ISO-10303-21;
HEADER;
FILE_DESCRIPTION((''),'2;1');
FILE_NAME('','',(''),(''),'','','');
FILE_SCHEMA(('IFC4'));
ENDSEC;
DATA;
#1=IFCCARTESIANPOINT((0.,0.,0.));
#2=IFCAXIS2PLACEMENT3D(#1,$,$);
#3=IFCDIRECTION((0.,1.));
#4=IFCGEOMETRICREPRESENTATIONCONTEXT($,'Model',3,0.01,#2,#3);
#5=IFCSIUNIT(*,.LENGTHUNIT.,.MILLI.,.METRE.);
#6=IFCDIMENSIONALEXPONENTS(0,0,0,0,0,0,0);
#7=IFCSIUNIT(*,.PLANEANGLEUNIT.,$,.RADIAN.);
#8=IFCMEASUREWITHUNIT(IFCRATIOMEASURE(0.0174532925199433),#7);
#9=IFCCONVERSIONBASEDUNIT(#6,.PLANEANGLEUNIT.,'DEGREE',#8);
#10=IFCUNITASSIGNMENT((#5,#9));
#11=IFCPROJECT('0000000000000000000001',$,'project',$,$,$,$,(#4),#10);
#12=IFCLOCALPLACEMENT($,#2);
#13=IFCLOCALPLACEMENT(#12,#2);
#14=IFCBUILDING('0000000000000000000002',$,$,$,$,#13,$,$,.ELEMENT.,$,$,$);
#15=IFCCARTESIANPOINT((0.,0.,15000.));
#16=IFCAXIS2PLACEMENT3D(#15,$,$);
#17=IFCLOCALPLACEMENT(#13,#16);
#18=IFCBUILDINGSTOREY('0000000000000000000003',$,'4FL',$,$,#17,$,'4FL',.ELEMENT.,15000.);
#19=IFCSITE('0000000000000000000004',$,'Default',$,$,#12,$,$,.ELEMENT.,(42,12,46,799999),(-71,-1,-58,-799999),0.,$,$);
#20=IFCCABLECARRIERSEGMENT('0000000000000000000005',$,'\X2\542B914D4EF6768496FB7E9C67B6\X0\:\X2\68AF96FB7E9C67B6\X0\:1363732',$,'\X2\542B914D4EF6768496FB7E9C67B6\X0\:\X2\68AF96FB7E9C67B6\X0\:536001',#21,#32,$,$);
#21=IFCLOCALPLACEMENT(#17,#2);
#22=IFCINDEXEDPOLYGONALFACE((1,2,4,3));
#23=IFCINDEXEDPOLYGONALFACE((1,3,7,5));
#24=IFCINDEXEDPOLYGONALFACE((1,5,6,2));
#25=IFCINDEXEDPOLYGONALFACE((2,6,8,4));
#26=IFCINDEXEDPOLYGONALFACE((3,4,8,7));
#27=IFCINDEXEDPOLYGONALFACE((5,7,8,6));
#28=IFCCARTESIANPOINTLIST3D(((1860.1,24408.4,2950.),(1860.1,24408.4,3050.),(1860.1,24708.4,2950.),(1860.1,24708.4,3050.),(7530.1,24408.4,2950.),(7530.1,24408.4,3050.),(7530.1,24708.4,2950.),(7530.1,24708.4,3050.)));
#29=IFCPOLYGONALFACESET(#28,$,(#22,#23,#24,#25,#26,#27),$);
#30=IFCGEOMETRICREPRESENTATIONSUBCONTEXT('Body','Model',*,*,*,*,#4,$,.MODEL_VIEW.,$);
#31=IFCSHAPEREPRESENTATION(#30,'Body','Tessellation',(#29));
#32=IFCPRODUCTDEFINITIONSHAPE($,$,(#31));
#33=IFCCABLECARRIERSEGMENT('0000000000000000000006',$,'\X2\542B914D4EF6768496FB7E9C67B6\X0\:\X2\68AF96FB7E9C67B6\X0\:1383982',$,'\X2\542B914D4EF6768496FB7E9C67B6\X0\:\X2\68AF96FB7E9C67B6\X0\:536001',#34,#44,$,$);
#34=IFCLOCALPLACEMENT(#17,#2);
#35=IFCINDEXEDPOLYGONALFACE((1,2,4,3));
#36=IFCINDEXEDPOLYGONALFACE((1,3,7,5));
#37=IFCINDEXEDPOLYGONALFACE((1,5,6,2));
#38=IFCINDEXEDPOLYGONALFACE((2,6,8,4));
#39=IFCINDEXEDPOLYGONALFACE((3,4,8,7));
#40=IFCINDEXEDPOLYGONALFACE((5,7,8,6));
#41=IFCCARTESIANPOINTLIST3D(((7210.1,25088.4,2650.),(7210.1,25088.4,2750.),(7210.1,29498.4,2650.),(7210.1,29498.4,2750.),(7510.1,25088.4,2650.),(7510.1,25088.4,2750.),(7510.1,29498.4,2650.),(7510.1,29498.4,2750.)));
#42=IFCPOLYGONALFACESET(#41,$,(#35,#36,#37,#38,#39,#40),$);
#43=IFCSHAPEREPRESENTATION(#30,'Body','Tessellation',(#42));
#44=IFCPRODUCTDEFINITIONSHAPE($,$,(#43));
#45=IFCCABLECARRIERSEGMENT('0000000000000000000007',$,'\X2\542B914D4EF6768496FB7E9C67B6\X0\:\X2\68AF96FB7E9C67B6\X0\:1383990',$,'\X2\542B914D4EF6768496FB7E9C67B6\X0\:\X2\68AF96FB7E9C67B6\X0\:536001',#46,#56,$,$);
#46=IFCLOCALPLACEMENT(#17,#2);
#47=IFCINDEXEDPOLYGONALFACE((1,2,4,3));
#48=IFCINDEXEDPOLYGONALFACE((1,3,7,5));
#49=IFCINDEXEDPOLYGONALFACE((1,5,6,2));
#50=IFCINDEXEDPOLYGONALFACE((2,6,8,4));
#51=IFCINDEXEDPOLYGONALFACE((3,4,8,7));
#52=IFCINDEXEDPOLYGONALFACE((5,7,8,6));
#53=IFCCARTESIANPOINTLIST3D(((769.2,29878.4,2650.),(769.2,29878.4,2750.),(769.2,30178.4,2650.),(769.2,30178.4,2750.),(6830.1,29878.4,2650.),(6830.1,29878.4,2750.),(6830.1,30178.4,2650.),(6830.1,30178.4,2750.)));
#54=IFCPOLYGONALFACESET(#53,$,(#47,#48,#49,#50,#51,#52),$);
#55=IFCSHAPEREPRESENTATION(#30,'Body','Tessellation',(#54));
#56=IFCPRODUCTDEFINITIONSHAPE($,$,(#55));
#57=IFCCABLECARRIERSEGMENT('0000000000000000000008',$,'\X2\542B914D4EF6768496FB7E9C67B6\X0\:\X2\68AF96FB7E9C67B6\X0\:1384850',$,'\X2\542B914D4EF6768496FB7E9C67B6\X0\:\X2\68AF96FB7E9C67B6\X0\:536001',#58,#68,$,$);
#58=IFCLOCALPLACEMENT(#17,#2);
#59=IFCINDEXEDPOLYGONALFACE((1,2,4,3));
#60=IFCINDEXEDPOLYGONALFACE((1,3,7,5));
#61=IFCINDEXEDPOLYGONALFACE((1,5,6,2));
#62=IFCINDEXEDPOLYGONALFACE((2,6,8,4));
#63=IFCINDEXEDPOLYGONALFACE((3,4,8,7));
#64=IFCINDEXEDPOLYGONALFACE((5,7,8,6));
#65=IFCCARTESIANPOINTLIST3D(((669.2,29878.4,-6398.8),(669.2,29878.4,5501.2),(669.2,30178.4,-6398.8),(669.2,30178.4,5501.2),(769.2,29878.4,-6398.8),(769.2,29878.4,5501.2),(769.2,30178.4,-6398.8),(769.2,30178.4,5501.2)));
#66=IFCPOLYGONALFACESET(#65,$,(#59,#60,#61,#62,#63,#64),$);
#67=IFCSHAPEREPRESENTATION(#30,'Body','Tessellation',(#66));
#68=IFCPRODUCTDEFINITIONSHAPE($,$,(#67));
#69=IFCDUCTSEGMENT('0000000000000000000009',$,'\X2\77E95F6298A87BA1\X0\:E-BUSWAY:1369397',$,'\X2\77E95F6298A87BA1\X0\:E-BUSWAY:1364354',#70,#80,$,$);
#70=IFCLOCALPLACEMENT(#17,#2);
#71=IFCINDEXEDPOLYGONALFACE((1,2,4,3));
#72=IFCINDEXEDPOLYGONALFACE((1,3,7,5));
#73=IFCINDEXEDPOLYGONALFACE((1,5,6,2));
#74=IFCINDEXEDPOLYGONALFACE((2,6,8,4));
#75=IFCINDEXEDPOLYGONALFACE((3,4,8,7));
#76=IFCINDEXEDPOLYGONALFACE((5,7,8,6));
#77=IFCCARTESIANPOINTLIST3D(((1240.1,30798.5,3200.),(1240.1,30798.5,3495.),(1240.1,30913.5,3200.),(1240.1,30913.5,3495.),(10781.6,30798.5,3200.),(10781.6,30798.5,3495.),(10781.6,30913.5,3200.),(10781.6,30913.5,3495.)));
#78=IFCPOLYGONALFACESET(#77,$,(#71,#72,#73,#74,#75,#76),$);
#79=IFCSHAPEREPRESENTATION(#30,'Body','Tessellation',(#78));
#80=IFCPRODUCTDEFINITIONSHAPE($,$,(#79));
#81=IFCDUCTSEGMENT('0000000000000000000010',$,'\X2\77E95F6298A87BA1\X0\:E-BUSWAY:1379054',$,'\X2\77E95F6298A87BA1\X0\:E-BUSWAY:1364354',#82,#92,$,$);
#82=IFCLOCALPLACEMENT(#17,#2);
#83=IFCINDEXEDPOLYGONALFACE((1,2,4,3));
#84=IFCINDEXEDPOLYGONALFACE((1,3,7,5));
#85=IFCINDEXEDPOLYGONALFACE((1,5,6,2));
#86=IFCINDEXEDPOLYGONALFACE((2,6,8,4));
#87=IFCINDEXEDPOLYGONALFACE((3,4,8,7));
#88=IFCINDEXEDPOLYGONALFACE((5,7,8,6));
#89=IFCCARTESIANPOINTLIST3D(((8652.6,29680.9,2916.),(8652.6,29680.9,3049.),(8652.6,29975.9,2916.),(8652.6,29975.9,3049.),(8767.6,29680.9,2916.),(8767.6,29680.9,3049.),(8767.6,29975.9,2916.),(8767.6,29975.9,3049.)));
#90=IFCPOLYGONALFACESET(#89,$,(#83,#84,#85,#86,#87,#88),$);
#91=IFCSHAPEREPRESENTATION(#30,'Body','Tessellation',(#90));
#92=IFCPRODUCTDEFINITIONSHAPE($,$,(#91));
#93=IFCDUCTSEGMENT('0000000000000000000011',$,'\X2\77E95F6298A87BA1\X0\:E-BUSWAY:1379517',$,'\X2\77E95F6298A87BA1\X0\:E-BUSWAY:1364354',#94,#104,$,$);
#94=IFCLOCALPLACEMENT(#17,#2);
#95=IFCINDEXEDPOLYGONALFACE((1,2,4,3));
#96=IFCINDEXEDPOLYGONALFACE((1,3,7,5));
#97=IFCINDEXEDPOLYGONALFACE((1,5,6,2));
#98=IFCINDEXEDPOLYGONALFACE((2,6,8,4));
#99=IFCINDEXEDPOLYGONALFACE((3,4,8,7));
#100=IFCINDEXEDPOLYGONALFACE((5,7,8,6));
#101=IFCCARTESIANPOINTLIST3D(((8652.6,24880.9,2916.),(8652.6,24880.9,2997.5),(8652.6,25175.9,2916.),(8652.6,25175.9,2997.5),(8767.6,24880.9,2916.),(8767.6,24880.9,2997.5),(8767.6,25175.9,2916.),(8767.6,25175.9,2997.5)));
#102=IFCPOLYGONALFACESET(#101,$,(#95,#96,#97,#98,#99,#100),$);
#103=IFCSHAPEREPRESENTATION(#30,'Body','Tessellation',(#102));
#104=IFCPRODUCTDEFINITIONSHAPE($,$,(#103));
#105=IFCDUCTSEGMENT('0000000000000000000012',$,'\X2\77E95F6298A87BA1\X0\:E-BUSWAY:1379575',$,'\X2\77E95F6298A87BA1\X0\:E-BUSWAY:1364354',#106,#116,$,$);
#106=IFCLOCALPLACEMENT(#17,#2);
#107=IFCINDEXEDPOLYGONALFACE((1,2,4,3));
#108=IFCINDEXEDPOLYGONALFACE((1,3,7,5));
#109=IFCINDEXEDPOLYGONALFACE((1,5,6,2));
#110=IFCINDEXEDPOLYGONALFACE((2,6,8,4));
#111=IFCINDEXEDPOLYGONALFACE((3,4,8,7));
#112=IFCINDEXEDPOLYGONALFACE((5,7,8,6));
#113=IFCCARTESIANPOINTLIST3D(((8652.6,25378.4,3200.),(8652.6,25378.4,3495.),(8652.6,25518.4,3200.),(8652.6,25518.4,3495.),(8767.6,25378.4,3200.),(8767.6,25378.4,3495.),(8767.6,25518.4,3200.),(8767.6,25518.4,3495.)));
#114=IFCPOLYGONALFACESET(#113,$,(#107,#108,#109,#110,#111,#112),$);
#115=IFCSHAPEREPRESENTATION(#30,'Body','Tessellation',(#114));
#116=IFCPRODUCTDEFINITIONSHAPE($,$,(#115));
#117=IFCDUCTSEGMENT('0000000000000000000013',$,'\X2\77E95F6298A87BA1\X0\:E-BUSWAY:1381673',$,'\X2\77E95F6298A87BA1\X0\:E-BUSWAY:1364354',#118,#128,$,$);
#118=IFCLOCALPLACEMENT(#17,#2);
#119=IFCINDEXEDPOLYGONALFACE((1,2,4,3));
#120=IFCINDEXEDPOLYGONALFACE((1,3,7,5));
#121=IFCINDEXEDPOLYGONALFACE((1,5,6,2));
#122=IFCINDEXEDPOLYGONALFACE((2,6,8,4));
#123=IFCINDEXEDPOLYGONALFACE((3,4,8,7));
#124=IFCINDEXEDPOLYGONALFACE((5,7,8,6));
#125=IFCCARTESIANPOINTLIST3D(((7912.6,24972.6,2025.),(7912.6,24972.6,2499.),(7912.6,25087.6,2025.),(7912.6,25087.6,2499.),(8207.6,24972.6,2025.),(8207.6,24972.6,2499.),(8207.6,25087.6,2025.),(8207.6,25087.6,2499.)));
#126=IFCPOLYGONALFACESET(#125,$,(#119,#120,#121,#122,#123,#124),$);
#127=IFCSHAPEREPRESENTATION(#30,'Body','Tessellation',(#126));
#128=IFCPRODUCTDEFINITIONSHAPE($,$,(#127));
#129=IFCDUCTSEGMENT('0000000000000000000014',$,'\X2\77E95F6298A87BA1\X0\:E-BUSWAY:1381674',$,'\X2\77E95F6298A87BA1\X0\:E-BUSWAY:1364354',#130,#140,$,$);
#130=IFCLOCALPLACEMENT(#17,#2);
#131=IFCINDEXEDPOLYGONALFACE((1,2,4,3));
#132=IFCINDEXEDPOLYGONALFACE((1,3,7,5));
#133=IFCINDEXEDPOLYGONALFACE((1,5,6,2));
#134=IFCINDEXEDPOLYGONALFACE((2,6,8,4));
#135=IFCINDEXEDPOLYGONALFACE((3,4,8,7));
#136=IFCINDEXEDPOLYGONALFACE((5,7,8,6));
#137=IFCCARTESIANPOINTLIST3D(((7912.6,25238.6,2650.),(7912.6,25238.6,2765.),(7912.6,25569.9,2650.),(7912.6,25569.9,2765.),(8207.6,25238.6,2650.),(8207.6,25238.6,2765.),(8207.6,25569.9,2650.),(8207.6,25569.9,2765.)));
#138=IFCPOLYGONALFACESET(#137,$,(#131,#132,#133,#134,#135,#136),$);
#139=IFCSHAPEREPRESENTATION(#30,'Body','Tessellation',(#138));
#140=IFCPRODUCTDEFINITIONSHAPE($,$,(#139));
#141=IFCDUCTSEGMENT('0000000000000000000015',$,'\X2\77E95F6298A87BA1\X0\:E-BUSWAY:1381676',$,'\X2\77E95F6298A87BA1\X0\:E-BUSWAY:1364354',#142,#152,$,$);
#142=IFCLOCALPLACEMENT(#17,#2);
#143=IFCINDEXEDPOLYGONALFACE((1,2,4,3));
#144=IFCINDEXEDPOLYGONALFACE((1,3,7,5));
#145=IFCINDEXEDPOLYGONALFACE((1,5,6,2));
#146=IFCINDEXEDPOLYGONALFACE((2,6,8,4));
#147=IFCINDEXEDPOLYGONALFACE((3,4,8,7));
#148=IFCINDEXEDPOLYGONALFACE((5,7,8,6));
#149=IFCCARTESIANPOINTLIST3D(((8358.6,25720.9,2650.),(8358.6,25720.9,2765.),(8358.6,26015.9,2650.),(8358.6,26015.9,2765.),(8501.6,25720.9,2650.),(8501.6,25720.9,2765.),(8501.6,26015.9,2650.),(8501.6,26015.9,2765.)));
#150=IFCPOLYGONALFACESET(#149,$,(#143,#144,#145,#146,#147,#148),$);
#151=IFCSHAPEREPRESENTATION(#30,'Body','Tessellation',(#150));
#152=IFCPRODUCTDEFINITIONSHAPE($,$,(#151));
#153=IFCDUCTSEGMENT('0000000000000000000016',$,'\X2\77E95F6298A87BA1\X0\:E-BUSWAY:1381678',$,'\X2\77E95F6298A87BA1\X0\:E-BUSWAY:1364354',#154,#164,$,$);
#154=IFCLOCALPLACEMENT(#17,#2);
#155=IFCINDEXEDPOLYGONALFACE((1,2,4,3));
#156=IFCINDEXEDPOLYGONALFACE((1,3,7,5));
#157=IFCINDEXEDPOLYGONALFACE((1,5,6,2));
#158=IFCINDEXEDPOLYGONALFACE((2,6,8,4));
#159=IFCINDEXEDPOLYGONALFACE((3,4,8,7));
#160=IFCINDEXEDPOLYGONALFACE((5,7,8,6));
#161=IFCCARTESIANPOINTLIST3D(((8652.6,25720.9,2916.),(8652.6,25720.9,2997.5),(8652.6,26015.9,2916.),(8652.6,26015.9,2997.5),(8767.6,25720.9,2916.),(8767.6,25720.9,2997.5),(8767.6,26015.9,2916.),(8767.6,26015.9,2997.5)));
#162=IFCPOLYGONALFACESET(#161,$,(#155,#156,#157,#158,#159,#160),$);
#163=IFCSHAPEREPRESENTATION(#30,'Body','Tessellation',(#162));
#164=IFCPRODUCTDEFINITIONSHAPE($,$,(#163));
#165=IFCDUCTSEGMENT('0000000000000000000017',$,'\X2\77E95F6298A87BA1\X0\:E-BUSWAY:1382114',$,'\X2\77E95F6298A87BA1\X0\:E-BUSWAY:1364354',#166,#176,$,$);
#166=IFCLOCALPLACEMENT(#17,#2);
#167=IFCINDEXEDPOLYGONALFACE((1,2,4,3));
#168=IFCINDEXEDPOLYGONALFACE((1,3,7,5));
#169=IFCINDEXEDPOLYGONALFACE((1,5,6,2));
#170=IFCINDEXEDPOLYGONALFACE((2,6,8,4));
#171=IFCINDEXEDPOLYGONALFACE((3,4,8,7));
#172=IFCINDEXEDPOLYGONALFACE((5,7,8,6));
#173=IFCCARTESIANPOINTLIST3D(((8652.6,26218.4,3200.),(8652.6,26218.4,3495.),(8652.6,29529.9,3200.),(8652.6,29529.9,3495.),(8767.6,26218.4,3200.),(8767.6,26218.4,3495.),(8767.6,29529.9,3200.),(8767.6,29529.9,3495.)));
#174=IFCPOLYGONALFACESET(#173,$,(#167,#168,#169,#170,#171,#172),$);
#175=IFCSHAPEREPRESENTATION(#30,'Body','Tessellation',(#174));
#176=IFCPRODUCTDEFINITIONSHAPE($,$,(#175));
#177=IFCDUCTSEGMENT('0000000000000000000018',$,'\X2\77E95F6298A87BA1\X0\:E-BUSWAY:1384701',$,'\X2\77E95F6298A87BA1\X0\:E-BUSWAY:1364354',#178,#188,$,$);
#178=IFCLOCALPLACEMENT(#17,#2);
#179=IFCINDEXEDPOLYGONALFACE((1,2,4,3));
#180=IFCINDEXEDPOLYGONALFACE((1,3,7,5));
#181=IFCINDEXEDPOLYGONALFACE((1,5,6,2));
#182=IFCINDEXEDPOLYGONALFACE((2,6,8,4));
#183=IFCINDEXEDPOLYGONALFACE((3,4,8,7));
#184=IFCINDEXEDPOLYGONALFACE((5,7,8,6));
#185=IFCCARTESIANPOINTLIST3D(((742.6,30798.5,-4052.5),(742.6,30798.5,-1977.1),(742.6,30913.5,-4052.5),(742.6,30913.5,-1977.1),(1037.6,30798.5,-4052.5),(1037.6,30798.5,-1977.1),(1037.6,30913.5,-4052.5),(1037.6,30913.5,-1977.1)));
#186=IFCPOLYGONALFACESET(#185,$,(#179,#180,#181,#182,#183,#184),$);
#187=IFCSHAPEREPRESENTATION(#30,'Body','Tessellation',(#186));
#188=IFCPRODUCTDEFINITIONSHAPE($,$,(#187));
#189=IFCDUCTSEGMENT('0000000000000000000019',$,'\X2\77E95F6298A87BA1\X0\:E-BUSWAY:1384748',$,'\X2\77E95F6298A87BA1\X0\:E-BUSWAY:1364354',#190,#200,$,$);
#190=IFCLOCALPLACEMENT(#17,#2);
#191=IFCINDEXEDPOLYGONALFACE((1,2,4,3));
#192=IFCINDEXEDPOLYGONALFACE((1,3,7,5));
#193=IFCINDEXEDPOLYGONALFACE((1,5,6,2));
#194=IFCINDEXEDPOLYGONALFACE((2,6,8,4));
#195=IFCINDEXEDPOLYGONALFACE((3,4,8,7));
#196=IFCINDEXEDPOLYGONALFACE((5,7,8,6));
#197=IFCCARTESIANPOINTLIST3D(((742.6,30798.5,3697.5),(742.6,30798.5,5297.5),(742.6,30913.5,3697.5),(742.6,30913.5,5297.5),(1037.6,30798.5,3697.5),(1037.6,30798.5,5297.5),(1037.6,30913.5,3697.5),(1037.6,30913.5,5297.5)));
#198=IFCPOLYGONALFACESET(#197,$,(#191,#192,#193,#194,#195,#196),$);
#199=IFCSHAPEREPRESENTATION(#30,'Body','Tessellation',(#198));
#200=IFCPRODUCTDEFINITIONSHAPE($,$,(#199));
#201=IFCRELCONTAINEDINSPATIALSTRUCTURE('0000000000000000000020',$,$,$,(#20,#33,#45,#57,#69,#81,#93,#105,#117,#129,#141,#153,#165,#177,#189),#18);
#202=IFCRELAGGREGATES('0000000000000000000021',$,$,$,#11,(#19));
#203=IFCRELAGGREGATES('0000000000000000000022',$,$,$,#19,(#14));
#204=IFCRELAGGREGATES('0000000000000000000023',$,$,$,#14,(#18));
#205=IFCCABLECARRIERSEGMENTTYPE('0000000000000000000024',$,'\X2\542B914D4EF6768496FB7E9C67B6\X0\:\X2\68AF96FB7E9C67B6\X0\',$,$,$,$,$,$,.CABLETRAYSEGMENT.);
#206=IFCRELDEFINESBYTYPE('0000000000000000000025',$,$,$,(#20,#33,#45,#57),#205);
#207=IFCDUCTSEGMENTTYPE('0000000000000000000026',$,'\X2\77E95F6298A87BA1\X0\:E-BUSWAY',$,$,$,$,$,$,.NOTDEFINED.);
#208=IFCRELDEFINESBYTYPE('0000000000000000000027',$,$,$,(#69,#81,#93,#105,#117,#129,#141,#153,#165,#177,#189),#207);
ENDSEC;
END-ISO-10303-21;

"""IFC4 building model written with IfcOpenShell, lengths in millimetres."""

from ifc_helpers import new_model, entity, si_unit, converted_unit, direction, frame, frame_2d, origin, origin_2d_with_axis, place, context, subcontext, project, spatial, rectangle, extrude, type_object, element, save


model = new_model("IFC4")

# Units and contexts
model_context = context("Model", 3, precision=0.01, world=origin(), true_north=direction((0.0, 1.0)))
body_context = subcontext(model_context, "Body", "Model", "MODEL_VIEW")
ifc_project = project(units=[si_unit("LENGTHUNIT", "METRE", prefix="MILLI"), converted_unit("PLANEANGLEUNIT", "DEGREE", entity("IfcRatioMeasure", 0.0174532925199433), si_unit("PLANEANGLEUNIT", "RADIAN"), dimensions=[0, 0, 0, 0, 0, 0, 0])], contexts=[model_context])

# Site, building, storey
site_placement = place(None, origin())
site = spatial("IfcSite", under=ifc_project, at=site_placement, Name="Default", CompositionType="ELEMENT", RefLatitude=(42, 12, 46, 799999), RefLongitude=(-71, -1, -58, -799999), RefElevation=0.0)
building_placement = place(site_placement, origin())
building = spatial("IfcBuilding", under=site, at=building_placement, CompositionType="ELEMENT")
storey_placement = place(building_placement, frame((0.0, 0.0, 15000.0)))
storey = spatial("IfcBuildingStorey", under=building, at=storey_placement, Name="4FL", LongName="4FL", CompositionType="ELEMENT", Elevation=15000.0)

# Cable carrier segments
cable_carrier_segment_type_1 = type_object("IfcCableCarrierSegmentType", Name="含配件的電纜架:梯電纜架", PredefinedType="CABLETRAYSEGMENT")
cable_carrier_segment_1_placement = place(storey_placement, frame((1860.1, 24408.4, 2950.0)))
element("IfcCableCarrierSegment", 1, at=cable_carrier_segment_1_placement, inside=storey, type_object=cable_carrier_segment_type_1, Name="含配件的電纜架:梯電纜架:1363732", ObjectType="含配件的電纜架:梯電纜架:536001", context=body_context, shape_type="SweptSolid", body=[
    extrude(rectangle(XDim=5670.0, YDim=300.0, at=origin_2d_with_axis()), frame((2835.0, 150.0, 0.0)), (0.0, 0.0, 1.0), 100.0),
])
cable_carrier_segment_2_placement = place(storey_placement, frame((7210.1, 25088.4, 2650.0)))
element("IfcCableCarrierSegment", 2, at=cable_carrier_segment_2_placement, inside=storey, type_object=cable_carrier_segment_type_1, Name="含配件的電纜架:梯電纜架:1383982", ObjectType="含配件的電纜架:梯電纜架:536001", context=body_context, shape_type="SweptSolid", body=[
    extrude(rectangle(XDim=4410.0, YDim=300.0, at=frame_2d((0.0, 0.0), x_axis=(1.0, 0.0))), frame((150.0, 2205.0, 0.0), z_axis=(0.0, 0.0, 1.0), x_axis=(0.0, 1.0, 0.0)), (0.0, 0.0, 1.0), 100.0),
])
cable_carrier_segment_3_placement = place(storey_placement, frame((769.2, 29878.4, 2650.0)))
element("IfcCableCarrierSegment", 3, at=cable_carrier_segment_3_placement, inside=storey, type_object=cable_carrier_segment_type_1, Name="含配件的電纜架:梯電纜架:1383990", ObjectType="含配件的電纜架:梯電纜架:536001", context=body_context, shape_type="SweptSolid", body=[
    extrude(rectangle(XDim=300.0, YDim=6060.9, at=frame_2d((0.0, 0.0), x_axis=(1.0, 0.0))), frame((3030.5, 150.0, 0.0), z_axis=(0.0, 0.0, 1.0), x_axis=(0.0, -1.0, 0.0)), (0.0, 0.0, 1.0), 100.0),
])
cable_carrier_segment_4_placement = place(storey_placement, frame((669.2, 29878.4, -6398.8)))
element("IfcCableCarrierSegment", 4, at=cable_carrier_segment_4_placement, inside=storey, type_object=cable_carrier_segment_type_1, Name="含配件的電纜架:梯電纜架:1384850", ObjectType="含配件的電纜架:梯電纜架:536001", context=body_context, shape_type="SweptSolid", body=[
    extrude(rectangle(XDim=100.0, YDim=300.0, at=origin_2d_with_axis()), frame((50.0, 150.0, 0.0)), (0.0, 0.0, 1.0), 11900.0),
])

# Duct segments
duct_segment_type = type_object("IfcDuctSegmentType", Name="矩形風管:E-BUSWAY", PredefinedType="NOTDEFINED")
duct_segment_1_placement = place(storey_placement, frame((1240.1, 30798.5, 3200.0)))
element("IfcDuctSegment", 5, at=duct_segment_1_placement, inside=storey, type_object=duct_segment_type, Name="矩形風管:E-BUSWAY:1369397", ObjectType="矩形風管:E-BUSWAY:1364354", context=body_context, shape_type="SweptSolid", body=[
    extrude(rectangle(XDim=9541.5, YDim=115.0, at=frame_2d((0.0, 0.0), x_axis=(1.0, 0.0))), frame((4770.8, 57.5, 0.0)), (0.0, 0.0, 1.0), 295.0),
])
duct_segment_2_placement = place(storey_placement, frame((8652.6, 29680.9, 2916.0)))
element("IfcDuctSegment", 6, at=duct_segment_2_placement, inside=storey, type_object=duct_segment_type, Name="矩形風管:E-BUSWAY:1379054", ObjectType="矩形風管:E-BUSWAY:1364354", context=body_context, shape_type="SweptSolid", body=[
    extrude(rectangle(XDim=115.0, YDim=295.0, at=frame_2d((0.0, 0.0), x_axis=(1.0, 0.0))), frame((57.5, 147.5, 0.0), z_axis=(0.0, 0.0, 1.0), x_axis=(-1.0, 0.0, 0.0)), (0.0, 0.0, 1.0), 133.0),
])
duct_segment_3_placement = place(storey_placement, frame((8652.6, 24880.9, 2916.0)))
element("IfcDuctSegment", 7, at=duct_segment_3_placement, inside=storey, type_object=duct_segment_type, Name="矩形風管:E-BUSWAY:1379517", ObjectType="矩形風管:E-BUSWAY:1364354", context=body_context, shape_type="SweptSolid", body=[
    extrude(rectangle(XDim=115.0, YDim=295.0, at=frame_2d((0.0, 0.0), x_axis=(1.0, 0.0))), frame((57.5, 147.5, 0.0), z_axis=(0.0, 0.0, 1.0), x_axis=(-1.0, 0.0, 0.0)), (0.0, 0.0, 1.0), 81.5),
])
duct_segment_4_placement = place(storey_placement, frame((8652.6, 25378.4, 3200.0)))
element("IfcDuctSegment", 8, at=duct_segment_4_placement, inside=storey, type_object=duct_segment_type, Name="矩形風管:E-BUSWAY:1379575", ObjectType="矩形風管:E-BUSWAY:1364354", context=body_context, shape_type="SweptSolid", body=[
    extrude(rectangle(XDim=140.0, YDim=115.0, at=frame_2d((0.0, 0.0), x_axis=(1.0, 0.0))), frame((57.5, 70.0, 0.0), z_axis=(0.0, 0.0, 1.0), x_axis=(0.0, -1.0, 0.0)), (0.0, 0.0, 1.0), 295.0),
])
duct_segment_5_placement = place(storey_placement, frame((7912.6, 24972.6, 2025.0)))
element("IfcDuctSegment", 9, at=duct_segment_5_placement, inside=storey, type_object=duct_segment_type, Name="矩形風管:E-BUSWAY:1381673", ObjectType="矩形風管:E-BUSWAY:1364354", context=body_context, shape_type="SweptSolid", body=[
    extrude(rectangle(XDim=115.0, YDim=295.0, at=frame_2d((0.0, 0.0), x_axis=(1.0, 0.0))), frame((147.5, 57.5, 0.0), z_axis=(0.0, 0.0, 1.0), x_axis=(0.0, -1.0, 0.0)), (0.0, 0.0, 1.0), 474.0),
])
duct_segment_6_placement = place(storey_placement, frame((7912.6, 25238.6, 2650.0)))
element("IfcDuctSegment", 10, at=duct_segment_6_placement, inside=storey, type_object=duct_segment_type, Name="矩形風管:E-BUSWAY:1381674", ObjectType="矩形風管:E-BUSWAY:1364354", context=body_context, shape_type="SweptSolid", body=[
    extrude(rectangle(XDim=331.3, YDim=295.0, at=frame_2d((0.0, 0.0), x_axis=(1.0, 0.0))), frame((147.5, 165.7, 0.0), z_axis=(0.0, 0.0, 1.0), x_axis=(0.0, 1.0, 0.0)), (0.0, 0.0, 1.0), 115.0),
])
duct_segment_7_placement = place(storey_placement, frame((8358.6, 25720.9, 2650.0)))
element("IfcDuctSegment", 11, at=duct_segment_7_placement, inside=storey, type_object=duct_segment_type, Name="矩形風管:E-BUSWAY:1381676", ObjectType="矩形風管:E-BUSWAY:1364354", context=body_context, shape_type="SweptSolid", body=[
    extrude(rectangle(XDim=143.0, YDim=295.0, at=frame_2d((0.0, 0.0), x_axis=(1.0, 0.0))), frame((71.5, 147.5, 0.0)), (0.0, 0.0, 1.0), 115.0),
])
duct_segment_8_placement = place(storey_placement, frame((8652.6, 25720.9, 2916.0)))
element("IfcDuctSegment", 12, at=duct_segment_8_placement, inside=storey, type_object=duct_segment_type, Name="矩形風管:E-BUSWAY:1381678", ObjectType="矩形風管:E-BUSWAY:1364354", context=body_context, shape_type="SweptSolid", body=[
    extrude(rectangle(XDim=115.0, YDim=295.0, at=origin_2d_with_axis()), frame((57.5, 147.5, 0.0)), (0.0, 0.0, 1.0), 81.5),
])
duct_segment_9_placement = place(storey_placement, frame((8652.6, 26218.4, 3200.0)))
element("IfcDuctSegment", 13, at=duct_segment_9_placement, inside=storey, type_object=duct_segment_type, Name="矩形風管:E-BUSWAY:1382114", ObjectType="矩形風管:E-BUSWAY:1364354", context=body_context, shape_type="SweptSolid", body=[
    extrude(rectangle(XDim=3311.5, YDim=115.0, at=frame_2d((0.0, 0.0), x_axis=(1.0, 0.0))), frame((57.5, 1655.8, 0.0), z_axis=(0.0, 0.0, 1.0), x_axis=(0.0, -1.0, 0.0)), (0.0, 0.0, 1.0), 295.0),
])
duct_segment_10_placement = place(storey_placement, frame((742.6, 30798.5, -4052.5)))
element("IfcDuctSegment", 14, at=duct_segment_10_placement, inside=storey, type_object=duct_segment_type, Name="矩形風管:E-BUSWAY:1384701", ObjectType="矩形風管:E-BUSWAY:1364354", context=body_context, shape_type="SweptSolid", body=[
    extrude(rectangle(XDim=115.0, YDim=295.0, at=frame_2d((0.0, 0.0), x_axis=(1.0, 0.0))), frame((147.5, 57.5, 0.0), z_axis=(0.0, 0.0, 1.0), x_axis=(0.0, 1.0, 0.0)), (0.0, 0.0, 1.0), 2075.4),
])
duct_segment_11_placement = place(storey_placement, frame((742.6, 30798.5, 3697.5)))
element("IfcDuctSegment", 15, at=duct_segment_11_placement, inside=storey, type_object=duct_segment_type, Name="矩形風管:E-BUSWAY:1384748", ObjectType="矩形風管:E-BUSWAY:1364354", context=body_context, shape_type="SweptSolid", body=[
    extrude(rectangle(XDim=295.0, YDim=115.0, at=frame_2d((0.0, 0.0), x_axis=(1.0, 0.0))), frame((147.5, 57.5, 0.0)), (0.0, 0.0, 1.0), 1600.0),
])

save(model, "model.ifc")
